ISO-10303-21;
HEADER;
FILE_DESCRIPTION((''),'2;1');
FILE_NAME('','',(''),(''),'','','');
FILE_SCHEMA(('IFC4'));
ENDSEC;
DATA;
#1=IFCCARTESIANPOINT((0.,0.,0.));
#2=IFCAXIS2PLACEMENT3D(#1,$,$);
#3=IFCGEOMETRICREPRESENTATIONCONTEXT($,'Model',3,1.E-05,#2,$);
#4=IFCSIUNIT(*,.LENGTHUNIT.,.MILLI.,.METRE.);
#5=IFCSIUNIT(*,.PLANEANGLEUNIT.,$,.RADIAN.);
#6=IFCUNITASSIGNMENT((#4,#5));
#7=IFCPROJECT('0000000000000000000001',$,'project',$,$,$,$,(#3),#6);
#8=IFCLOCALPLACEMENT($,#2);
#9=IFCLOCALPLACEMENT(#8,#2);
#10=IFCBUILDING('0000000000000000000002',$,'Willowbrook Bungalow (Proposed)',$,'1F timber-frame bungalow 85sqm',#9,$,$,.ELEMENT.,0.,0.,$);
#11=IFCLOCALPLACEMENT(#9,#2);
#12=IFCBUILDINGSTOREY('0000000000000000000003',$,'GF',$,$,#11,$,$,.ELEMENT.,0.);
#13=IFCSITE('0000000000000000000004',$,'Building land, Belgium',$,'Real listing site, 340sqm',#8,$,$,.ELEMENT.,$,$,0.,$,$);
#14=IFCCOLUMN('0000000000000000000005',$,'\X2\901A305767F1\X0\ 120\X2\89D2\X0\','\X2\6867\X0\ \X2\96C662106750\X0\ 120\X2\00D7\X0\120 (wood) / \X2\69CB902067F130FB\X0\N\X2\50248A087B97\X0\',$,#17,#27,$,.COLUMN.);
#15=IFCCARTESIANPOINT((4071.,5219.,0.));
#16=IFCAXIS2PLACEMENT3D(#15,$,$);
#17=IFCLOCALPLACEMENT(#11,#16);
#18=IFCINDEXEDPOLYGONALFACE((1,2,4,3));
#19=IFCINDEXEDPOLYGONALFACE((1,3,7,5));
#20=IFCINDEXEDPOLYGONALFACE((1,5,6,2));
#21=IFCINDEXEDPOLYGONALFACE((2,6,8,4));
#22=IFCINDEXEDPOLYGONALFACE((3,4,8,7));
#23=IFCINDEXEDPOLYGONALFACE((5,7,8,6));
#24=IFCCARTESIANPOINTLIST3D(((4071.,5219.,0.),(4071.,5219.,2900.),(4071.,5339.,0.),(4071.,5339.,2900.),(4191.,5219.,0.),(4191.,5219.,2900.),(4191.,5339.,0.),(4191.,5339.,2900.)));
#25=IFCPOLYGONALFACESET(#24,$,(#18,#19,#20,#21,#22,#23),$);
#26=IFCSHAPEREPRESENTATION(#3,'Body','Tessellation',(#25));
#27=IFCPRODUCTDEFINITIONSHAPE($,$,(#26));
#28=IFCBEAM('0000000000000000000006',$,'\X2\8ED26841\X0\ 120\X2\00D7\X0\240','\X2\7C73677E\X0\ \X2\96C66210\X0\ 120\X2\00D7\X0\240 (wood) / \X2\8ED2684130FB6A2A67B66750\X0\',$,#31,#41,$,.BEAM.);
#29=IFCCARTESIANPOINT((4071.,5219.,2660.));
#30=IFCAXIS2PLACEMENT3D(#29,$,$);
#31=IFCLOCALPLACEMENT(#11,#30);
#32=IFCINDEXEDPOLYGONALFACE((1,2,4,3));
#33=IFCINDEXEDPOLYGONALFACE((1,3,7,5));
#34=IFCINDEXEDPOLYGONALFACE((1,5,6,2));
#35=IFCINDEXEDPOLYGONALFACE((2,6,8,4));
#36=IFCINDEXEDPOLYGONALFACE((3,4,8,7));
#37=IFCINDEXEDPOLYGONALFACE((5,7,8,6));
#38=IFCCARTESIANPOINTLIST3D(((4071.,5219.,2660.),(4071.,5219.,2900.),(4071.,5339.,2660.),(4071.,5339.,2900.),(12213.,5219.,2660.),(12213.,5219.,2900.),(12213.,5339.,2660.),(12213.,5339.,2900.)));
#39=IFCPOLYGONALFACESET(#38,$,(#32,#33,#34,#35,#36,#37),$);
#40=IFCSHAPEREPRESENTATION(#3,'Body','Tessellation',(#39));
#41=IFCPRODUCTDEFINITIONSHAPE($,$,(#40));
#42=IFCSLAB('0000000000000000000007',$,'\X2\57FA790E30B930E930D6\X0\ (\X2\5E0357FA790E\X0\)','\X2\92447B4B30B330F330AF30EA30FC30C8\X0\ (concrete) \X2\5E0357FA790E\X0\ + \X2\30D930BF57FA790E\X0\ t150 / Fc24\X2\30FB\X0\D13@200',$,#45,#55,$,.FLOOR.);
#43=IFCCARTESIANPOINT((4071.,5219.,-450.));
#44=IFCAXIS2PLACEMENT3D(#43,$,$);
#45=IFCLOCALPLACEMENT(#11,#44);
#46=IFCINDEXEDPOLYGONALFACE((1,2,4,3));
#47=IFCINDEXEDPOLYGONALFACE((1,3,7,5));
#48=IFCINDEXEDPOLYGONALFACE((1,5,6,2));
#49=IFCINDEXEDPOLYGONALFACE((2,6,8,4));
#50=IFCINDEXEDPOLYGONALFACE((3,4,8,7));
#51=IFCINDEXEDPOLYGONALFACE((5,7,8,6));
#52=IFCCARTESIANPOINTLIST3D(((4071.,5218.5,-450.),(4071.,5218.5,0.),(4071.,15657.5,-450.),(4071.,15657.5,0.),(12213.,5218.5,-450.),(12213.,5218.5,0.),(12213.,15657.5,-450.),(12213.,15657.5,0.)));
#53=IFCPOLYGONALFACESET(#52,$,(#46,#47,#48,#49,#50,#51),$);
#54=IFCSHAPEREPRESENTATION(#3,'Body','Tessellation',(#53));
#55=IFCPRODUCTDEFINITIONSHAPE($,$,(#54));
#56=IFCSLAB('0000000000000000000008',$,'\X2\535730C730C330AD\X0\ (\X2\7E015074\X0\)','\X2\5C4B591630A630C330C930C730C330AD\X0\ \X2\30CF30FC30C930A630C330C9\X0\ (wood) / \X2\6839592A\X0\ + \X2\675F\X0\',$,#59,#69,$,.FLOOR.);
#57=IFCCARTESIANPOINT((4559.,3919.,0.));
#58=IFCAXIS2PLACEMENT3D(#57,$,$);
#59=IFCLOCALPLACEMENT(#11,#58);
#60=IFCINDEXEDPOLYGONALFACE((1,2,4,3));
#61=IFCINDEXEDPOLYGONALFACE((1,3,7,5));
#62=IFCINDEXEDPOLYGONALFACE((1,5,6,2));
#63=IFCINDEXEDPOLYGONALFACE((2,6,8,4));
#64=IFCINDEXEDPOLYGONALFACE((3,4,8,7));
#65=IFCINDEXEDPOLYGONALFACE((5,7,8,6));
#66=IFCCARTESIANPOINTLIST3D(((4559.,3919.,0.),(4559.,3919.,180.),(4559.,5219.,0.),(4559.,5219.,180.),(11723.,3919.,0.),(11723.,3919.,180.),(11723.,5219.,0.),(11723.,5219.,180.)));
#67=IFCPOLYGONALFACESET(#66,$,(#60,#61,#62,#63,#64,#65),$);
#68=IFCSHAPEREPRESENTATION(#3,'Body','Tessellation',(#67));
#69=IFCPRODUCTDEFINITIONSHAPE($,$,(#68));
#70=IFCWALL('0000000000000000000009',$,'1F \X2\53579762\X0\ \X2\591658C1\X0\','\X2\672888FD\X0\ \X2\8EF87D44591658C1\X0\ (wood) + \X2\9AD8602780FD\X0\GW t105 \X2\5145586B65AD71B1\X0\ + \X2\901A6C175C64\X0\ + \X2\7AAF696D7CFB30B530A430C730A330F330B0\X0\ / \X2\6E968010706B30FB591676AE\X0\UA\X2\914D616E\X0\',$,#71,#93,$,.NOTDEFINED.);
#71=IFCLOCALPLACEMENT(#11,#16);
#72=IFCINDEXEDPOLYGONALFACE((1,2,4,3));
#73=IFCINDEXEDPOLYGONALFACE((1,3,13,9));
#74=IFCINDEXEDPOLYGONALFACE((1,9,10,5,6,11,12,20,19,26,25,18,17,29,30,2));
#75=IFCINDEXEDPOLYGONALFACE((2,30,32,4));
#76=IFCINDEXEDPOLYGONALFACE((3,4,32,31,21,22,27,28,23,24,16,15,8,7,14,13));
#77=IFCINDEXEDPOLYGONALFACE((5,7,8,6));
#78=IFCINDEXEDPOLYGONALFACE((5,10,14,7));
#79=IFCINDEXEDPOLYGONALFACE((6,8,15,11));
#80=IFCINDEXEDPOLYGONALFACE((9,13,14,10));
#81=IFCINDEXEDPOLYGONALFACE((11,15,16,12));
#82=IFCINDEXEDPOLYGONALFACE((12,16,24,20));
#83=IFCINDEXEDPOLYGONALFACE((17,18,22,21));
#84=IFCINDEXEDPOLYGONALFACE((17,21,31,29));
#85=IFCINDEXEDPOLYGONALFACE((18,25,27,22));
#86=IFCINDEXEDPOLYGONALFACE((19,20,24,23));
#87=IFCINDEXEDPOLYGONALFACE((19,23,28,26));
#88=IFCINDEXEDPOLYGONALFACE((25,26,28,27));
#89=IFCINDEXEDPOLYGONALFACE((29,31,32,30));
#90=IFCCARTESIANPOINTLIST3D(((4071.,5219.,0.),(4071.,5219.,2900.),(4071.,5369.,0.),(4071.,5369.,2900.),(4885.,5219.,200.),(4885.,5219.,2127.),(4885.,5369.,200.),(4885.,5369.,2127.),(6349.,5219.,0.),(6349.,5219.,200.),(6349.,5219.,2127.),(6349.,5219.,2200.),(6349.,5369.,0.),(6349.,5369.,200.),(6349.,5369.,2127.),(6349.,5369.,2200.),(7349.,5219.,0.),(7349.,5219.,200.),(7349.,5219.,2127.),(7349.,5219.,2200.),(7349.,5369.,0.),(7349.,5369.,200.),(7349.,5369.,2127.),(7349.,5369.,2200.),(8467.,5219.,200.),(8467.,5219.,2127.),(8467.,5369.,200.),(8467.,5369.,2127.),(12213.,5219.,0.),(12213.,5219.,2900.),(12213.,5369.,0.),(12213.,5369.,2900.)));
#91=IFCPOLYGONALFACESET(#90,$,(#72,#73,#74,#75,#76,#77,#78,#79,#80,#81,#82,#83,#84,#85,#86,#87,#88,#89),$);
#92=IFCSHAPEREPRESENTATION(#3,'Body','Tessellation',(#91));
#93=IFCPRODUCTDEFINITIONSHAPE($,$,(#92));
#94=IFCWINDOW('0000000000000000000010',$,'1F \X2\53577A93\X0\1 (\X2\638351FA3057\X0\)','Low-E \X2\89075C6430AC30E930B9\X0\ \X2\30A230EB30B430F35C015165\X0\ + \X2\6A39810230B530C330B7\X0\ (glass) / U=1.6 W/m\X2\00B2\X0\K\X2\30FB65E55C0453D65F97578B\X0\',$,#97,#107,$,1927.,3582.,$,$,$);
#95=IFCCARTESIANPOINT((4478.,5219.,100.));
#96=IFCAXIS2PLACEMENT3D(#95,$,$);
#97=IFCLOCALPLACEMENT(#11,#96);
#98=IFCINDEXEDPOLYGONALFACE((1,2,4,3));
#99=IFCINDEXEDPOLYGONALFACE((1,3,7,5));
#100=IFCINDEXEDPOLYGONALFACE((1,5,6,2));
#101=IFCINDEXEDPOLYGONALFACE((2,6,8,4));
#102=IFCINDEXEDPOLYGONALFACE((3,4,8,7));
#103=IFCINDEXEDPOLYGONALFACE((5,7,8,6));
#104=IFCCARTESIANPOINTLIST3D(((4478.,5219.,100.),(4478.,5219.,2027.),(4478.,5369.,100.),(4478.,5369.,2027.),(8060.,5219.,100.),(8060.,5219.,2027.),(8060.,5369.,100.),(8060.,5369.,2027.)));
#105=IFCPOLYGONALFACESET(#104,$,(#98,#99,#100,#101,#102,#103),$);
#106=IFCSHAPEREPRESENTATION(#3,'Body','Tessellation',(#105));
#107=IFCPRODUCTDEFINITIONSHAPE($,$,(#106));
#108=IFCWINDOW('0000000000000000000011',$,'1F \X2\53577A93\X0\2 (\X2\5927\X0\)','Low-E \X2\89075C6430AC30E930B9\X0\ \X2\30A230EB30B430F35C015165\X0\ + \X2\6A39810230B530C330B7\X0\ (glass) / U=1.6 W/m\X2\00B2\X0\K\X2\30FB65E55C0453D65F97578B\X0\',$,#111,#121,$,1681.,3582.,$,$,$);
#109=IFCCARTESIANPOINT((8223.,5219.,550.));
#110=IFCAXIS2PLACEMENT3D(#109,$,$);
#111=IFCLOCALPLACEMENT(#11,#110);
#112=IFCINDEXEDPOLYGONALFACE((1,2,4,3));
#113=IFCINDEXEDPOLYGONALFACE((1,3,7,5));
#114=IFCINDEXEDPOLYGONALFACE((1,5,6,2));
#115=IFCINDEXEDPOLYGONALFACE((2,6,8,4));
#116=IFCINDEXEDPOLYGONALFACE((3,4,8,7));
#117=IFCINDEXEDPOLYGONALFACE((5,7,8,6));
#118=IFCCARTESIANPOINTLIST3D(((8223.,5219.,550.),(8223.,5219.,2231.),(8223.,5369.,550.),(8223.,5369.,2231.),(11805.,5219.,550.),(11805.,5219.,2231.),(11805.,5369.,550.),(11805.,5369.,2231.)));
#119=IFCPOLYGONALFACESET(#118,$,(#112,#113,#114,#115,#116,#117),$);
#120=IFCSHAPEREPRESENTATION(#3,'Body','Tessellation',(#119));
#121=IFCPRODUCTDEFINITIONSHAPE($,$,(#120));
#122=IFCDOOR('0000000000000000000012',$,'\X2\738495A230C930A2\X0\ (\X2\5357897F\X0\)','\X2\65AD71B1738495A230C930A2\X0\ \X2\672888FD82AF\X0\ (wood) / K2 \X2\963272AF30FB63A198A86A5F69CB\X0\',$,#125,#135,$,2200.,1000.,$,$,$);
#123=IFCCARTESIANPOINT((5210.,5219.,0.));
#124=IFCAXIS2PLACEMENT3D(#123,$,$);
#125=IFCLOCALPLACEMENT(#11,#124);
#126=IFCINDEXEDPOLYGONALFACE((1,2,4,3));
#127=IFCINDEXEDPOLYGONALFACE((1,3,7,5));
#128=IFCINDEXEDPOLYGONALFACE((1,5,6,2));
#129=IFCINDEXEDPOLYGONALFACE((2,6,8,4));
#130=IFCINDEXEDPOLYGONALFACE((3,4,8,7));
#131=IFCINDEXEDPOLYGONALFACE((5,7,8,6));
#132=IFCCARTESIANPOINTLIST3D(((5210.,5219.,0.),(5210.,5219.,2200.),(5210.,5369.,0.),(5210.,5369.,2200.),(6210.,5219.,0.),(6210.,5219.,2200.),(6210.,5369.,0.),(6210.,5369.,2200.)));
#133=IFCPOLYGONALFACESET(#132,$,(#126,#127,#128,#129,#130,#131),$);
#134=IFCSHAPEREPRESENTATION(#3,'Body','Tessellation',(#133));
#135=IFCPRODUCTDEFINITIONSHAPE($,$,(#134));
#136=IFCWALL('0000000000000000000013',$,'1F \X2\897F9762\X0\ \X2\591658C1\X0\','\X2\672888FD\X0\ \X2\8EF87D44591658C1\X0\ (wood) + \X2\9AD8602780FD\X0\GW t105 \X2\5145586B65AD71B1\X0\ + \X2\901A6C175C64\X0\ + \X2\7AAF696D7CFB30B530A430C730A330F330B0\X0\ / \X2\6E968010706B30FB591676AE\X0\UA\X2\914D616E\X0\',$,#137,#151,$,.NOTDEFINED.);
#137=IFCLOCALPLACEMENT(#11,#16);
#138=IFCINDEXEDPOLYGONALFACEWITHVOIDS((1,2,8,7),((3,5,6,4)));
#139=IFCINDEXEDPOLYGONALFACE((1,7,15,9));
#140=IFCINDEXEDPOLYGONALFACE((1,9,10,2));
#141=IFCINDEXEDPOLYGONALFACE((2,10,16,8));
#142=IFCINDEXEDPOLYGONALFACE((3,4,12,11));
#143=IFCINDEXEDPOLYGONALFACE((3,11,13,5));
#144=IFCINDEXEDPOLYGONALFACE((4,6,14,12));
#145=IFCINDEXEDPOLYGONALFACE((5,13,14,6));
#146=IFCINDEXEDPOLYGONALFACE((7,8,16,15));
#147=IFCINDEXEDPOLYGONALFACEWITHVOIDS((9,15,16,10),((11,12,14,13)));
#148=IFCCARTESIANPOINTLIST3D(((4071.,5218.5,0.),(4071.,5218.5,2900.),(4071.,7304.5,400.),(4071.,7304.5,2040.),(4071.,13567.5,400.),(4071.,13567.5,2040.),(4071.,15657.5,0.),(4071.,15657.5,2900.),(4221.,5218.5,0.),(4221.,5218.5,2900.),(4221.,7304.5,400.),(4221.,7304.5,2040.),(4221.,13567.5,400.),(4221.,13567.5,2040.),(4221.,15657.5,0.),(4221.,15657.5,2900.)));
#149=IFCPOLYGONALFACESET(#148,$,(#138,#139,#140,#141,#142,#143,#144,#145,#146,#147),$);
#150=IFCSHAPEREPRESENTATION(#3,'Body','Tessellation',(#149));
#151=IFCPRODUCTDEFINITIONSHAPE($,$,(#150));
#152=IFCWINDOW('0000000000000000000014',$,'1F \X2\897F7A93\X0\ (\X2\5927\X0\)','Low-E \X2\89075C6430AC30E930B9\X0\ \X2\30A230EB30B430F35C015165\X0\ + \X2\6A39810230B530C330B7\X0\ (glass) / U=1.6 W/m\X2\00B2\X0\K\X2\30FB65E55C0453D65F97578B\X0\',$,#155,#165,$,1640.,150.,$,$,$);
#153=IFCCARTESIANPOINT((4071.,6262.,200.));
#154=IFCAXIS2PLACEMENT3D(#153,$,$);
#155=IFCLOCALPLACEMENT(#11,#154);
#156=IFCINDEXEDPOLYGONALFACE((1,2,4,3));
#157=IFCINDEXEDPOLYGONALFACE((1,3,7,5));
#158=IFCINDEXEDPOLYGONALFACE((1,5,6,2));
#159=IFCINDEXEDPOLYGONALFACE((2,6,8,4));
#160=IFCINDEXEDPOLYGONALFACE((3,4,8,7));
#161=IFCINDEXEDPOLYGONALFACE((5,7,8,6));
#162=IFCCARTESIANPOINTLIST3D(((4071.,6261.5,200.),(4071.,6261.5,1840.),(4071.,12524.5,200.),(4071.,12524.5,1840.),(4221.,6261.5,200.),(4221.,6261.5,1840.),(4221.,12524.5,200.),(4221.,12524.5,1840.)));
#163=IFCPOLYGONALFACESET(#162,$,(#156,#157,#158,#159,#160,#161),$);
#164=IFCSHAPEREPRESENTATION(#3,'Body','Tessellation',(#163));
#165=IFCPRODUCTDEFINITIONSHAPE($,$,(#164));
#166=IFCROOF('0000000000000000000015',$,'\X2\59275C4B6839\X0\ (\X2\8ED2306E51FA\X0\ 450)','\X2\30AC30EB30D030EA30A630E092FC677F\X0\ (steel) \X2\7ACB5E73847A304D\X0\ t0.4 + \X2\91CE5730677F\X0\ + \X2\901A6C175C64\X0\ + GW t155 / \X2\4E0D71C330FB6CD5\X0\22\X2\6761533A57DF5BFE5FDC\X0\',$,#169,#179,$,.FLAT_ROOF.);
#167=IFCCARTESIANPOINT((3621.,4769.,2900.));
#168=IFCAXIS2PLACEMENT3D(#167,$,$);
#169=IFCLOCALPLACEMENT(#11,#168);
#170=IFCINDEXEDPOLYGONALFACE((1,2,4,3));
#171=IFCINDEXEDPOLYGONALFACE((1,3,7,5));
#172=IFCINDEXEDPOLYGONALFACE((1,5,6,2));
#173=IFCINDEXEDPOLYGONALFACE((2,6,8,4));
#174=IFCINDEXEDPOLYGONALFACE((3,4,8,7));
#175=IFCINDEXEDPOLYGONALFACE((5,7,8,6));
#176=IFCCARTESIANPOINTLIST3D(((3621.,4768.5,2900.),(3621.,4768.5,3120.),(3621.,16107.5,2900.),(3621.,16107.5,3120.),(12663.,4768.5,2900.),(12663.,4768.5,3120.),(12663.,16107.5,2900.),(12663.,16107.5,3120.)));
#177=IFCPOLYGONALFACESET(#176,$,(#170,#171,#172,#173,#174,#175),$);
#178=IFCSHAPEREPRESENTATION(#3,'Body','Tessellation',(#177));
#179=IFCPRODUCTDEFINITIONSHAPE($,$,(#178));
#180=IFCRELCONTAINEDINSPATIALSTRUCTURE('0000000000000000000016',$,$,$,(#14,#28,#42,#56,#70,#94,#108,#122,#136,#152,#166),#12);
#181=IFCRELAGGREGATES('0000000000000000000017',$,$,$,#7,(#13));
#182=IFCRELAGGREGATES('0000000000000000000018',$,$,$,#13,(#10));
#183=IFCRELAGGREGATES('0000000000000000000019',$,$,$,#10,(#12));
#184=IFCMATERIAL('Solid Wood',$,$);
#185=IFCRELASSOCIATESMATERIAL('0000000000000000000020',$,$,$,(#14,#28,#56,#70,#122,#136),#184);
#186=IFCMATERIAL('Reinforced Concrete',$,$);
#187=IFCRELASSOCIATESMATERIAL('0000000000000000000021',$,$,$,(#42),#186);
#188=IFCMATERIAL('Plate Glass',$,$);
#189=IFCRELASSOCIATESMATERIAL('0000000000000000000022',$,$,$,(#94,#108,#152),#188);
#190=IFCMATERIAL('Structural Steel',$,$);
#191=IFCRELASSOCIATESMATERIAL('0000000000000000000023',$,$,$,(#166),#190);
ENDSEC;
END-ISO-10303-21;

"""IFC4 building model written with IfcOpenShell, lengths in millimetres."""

from ifc_helpers import new_model, si_unit, frame, frame_2d, origin, place, context, project, spatial, rectangle, extrude, material, element, fill, save


model = new_model("IFC4")

# Units and contexts
model_context = context("Model", 3, precision=1e-05, world=origin())
ifc_project = project(units=[si_unit("LENGTHUNIT", "METRE", prefix="MILLI"), si_unit("PLANEANGLEUNIT", "RADIAN")], contexts=[model_context])

# Site, building, storey
site_placement = place(None, origin())
site = spatial("IfcSite", under=ifc_project, at=site_placement, Name="Building land, Belgium", ObjectType="Real listing site, 340sqm", CompositionType="ELEMENT", RefElevation=0.0)
building_placement = place(site_placement, origin())
building = spatial("IfcBuilding", under=site, at=building_placement, Name="Willowbrook Bungalow (Proposed)", ObjectType="1F timber-frame bungalow 85sqm", CompositionType="ELEMENT", ElevationOfRefHeight=0.0, ElevationOfTerrain=0.0)
storey_placement = place(building_placement, origin())
storey = spatial("IfcBuildingStorey", under=building, at=storey_placement, Name="GF", CompositionType="ELEMENT", Elevation=0.0)

# Column
ifc_material_1 = material(Name="Solid Wood")
column_1_placement = place(storey_placement, frame((4071.0, 5219.0, 0.0)))
element("IfcColumn", 1, at=column_1_placement, inside=storey, material=ifc_material_1, Name="通し柱 120角", Description="桧 集成材 120×120 (wood) / 構造柱・N値計算", PredefinedType="COLUMN", context=model_context, shape_type="SweptSolid", body=[
    extrude(rectangle(XDim=120.0, YDim=120.0, at=frame_2d((60.0, 60.0))), frame((4071.0, 5219.0, 0.0)), (0.0, 0.0, 1.0), 2900.0),
])

# Beam
beam_1_placement = place(storey_placement, frame((4071.0, 5219.0, 2660.0)))
element("IfcBeam", 2, at=beam_1_placement, inside=storey, material=ifc_material_1, Name="軒桁 120×240", Description="米松 集成 120×240 (wood) / 軒桁・横架材", PredefinedType="BEAM", context=model_context, shape_type="SweptSolid", body=[
    extrude(rectangle(XDim=8142.0, YDim=120.0, at=frame_2d((4071.0, 60.0))), frame((4071.0, 5219.0, 2660.0)), (0.0, 0.0, 1.0), 240.0),
])

# Slabs
ifc_material_2 = material(Name="Reinforced Concrete")
slab_1_placement = place(storey_placement, frame((4071.0, 5219.0, -450.0)))
element("IfcSlab", 3, at=slab_1_placement, inside=storey, material=ifc_material_2, Name="基礎スラブ (布基礎)", Description="鉄筋コンクリート (concrete) 布基礎 + ベタ基礎 t150 / Fc24・D13@200", PredefinedType="FLOOR", context=model_context, shape_type="SweptSolid", body=[
    extrude(rectangle(XDim=8142.0, YDim=10439.0, at=frame_2d((4071.0, 5219.0))), frame((4071.0, 5219.0, -450.0)), (0.0, 0.0, 1.0), 450.0),
])
slab_2_placement = place(storey_placement, frame((4559.0, 3919.0, 0.0)))
element("IfcSlab", 4, at=slab_2_placement, inside=storey, material=ifc_material_1, Name="南デッキ (縁側)", Description="屋外ウッドデッキ ハードウッド (wood) / 根太 + 束", PredefinedType="FLOOR", context=model_context, shape_type="SweptSolid", body=[
    extrude(rectangle(XDim=7164.0, YDim=1300.0, at=frame_2d((3582.0, 650.0))), frame((4559.0, 3919.0, 0.0)), (0.0, 0.0, 1.0), 180.0),
])

# Wall, openings, windows, door
wall_1_placement = place(storey_placement, frame((4071.0, 5219.0, 0.0)))
wall_1 = element("IfcWall", 5, at=wall_1_placement, inside=storey, material=ifc_material_1, Name="1F 南面 外壁", Description="木製 軸組外壁 (wood) + 高性能GW t105 充填断熱 + 通気層 + 窯業系サイディング / 準耐火・外皮UA配慮", PredefinedType="NOTDEFINED", context=model_context, shape_type="SweptSolid", body=[
    extrude(rectangle(XDim=8142.0, YDim=150.0, at=frame_2d((4071.0, 75.0))), frame((4071.0, 5219.0, 0.0)), (0.0, 0.0, 1.0), 2900.0),
])
opening_1_placement = place(storey_placement, frame((4478.0, 5219.0, 100.0)))
opening_1 = element("IfcOpeningElement", 6, at=opening_1_placement, cuts=wall_1, PredefinedType="NOTDEFINED", context=model_context, shape_type="SweptSolid", body=[
    extrude(rectangle(XDim=3582.0, YDim=150.0, at=frame_2d((1791.0, 75.0))), frame((4478.0, 5219.0, 100.0)), (0.0, 0.0, 1.0), 1927.0),
])
opening_2_placement = place(storey_placement, frame((8223.0, 5219.0, 550.0)))
opening_2 = element("IfcOpeningElement", 7, at=opening_2_placement, cuts=wall_1, PredefinedType="NOTDEFINED", context=model_context, shape_type="SweptSolid", body=[
    extrude(rectangle(XDim=3582.0, YDim=150.0, at=frame_2d((1791.0, 75.0))), frame((8223.0, 5219.0, 550.0)), (0.0, 0.0, 1.0), 1681.0),
])
opening_3_placement = place(storey_placement, frame((5210.0, 5219.0, 0.0)))
opening_3 = element("IfcOpeningElement", 8, at=opening_3_placement, cuts=wall_1, PredefinedType="NOTDEFINED", context=model_context, shape_type="SweptSolid", body=[
    extrude(rectangle(XDim=1000.0, YDim=150.0, at=frame_2d((500.0, 75.0))), frame((5210.0, 5219.0, 0.0)), (0.0, 0.0, 1.0), 2200.0),
])
ifc_material_3 = material(Name="Plate Glass")
window_1_placement = place(storey_placement, frame((4478.0, 5219.0, 100.0)))
window_1 = element("IfcWindow", 9, at=window_1_placement, inside=storey, material=ifc_material_3, Name="1F 南窓1 (掃出し)", Description="Low-E 複層ガラス アルゴン封入 + 樹脂サッシ (glass) / U=1.6 W/m²K・日射取得型", OverallHeight=1927.0, OverallWidth=3582.0, context=model_context, shape_type="SweptSolid", body=[
    extrude(rectangle(XDim=3582.0, YDim=150.0, at=frame_2d((1791.0, 75.0))), frame((4478.0, 5219.0, 100.0)), (0.0, 0.0, 1.0), 1927.0),
])
fill(opening_1, window_1)
window_2_placement = place(storey_placement, frame((8223.0, 5219.0, 550.0)))
window_2 = element("IfcWindow", 10, at=window_2_placement, inside=storey, material=ifc_material_3, Name="1F 南窓2 (大)", Description="Low-E 複層ガラス アルゴン封入 + 樹脂サッシ (glass) / U=1.6 W/m²K・日射取得型", OverallHeight=1681.0, OverallWidth=3582.0, context=model_context, shape_type="SweptSolid", body=[
    extrude(rectangle(XDim=3582.0, YDim=150.0, at=frame_2d((1791.0, 75.0))), frame((8223.0, 5219.0, 550.0)), (0.0, 0.0, 1.0), 1681.0),
])
fill(opening_2, window_2)
door_placement = place(storey_placement, frame((5210.0, 5219.0, 0.0)))
door = element("IfcDoor", 11, at=door_placement, inside=storey, material=ifc_material_1, Name="玄関ドア (南西)", Description="断熱玄関ドア 木製芯 (wood) / K2 防犯・採風機構", OverallHeight=2200.0, OverallWidth=1000.0, context=model_context, shape_type="SweptSolid", body=[
    extrude(rectangle(XDim=1000.0, YDim=150.0, at=frame_2d((500.0, 75.0))), frame((5210.0, 5219.0, 0.0)), (0.0, 0.0, 1.0), 2200.0),
])
fill(opening_3, door)

# Wall, opening, window
wall_2_placement = place(storey_placement, frame((4071.0, 5219.0, 0.0)))
wall_2 = element("IfcWall", 12, at=wall_2_placement, inside=storey, material=ifc_material_1, Name="1F 西面 外壁", Description="木製 軸組外壁 (wood) + 高性能GW t105 充填断熱 + 通気層 + 窯業系サイディング / 準耐火・外皮UA配慮", PredefinedType="NOTDEFINED", context=model_context, shape_type="SweptSolid", body=[
    extrude(rectangle(XDim=150.0, YDim=10439.0, at=frame_2d((75.0, 5219.0))), frame((4071.0, 5219.0, 0.0)), (0.0, 0.0, 1.0), 2900.0),
])
opening_4_placement = place(storey_placement, frame((4071.0, 6262.0, 200.0)))
opening_4 = element("IfcOpeningElement", 13, at=opening_4_placement, cuts=wall_2, PredefinedType="NOTDEFINED", context=model_context, shape_type="SweptSolid", body=[
    extrude(rectangle(XDim=150.0, YDim=6263.0, at=frame_2d((75.0, 3131.0))), frame((4071.0, 6262.0, 200.0)), (0.0, 0.0, 1.0), 1640.0),
])
window_3_placement = place(storey_placement, frame((4071.0, 6262.0, 200.0)))
window_3 = element("IfcWindow", 14, at=window_3_placement, inside=storey, material=ifc_material_3, Name="1F 西窓 (大)", Description="Low-E 複層ガラス アルゴン封入 + 樹脂サッシ (glass) / U=1.6 W/m²K・日射取得型", OverallHeight=1640.0, OverallWidth=150.0, context=model_context, shape_type="SweptSolid", body=[
    extrude(rectangle(XDim=150.0, YDim=6263.0, at=frame_2d((75.0, 3131.0))), frame((4071.0, 6262.0, 200.0)), (0.0, 0.0, 1.0), 1640.0),
])
fill(opening_4, window_3)

# Roof
ifc_material_4 = material(Name="Structural Steel")
roof_placement = place(storey_placement, frame((3621.0, 4769.0, 2900.0)))
element("IfcRoof", 15, at=roof_placement, inside=storey, material=ifc_material_4, Name="大屋根 (軒の出 450)", Description="ガルバリウム鋼板 (steel) 立平葺き t0.4 + 野地板 + 通気層 + GW t155 / 不燃・法22条区域対応", PredefinedType="FLAT_ROOF", context=model_context, shape_type="SweptSolid", body=[
    extrude(rectangle(XDim=9042.0, YDim=11339.0, at=frame_2d((4521.0, 5669.0))), frame((3621.0, 4769.0, 2900.0)), (0.0, 0.0, 1.0), 220.0),
])

save(model, "model.ifc")
